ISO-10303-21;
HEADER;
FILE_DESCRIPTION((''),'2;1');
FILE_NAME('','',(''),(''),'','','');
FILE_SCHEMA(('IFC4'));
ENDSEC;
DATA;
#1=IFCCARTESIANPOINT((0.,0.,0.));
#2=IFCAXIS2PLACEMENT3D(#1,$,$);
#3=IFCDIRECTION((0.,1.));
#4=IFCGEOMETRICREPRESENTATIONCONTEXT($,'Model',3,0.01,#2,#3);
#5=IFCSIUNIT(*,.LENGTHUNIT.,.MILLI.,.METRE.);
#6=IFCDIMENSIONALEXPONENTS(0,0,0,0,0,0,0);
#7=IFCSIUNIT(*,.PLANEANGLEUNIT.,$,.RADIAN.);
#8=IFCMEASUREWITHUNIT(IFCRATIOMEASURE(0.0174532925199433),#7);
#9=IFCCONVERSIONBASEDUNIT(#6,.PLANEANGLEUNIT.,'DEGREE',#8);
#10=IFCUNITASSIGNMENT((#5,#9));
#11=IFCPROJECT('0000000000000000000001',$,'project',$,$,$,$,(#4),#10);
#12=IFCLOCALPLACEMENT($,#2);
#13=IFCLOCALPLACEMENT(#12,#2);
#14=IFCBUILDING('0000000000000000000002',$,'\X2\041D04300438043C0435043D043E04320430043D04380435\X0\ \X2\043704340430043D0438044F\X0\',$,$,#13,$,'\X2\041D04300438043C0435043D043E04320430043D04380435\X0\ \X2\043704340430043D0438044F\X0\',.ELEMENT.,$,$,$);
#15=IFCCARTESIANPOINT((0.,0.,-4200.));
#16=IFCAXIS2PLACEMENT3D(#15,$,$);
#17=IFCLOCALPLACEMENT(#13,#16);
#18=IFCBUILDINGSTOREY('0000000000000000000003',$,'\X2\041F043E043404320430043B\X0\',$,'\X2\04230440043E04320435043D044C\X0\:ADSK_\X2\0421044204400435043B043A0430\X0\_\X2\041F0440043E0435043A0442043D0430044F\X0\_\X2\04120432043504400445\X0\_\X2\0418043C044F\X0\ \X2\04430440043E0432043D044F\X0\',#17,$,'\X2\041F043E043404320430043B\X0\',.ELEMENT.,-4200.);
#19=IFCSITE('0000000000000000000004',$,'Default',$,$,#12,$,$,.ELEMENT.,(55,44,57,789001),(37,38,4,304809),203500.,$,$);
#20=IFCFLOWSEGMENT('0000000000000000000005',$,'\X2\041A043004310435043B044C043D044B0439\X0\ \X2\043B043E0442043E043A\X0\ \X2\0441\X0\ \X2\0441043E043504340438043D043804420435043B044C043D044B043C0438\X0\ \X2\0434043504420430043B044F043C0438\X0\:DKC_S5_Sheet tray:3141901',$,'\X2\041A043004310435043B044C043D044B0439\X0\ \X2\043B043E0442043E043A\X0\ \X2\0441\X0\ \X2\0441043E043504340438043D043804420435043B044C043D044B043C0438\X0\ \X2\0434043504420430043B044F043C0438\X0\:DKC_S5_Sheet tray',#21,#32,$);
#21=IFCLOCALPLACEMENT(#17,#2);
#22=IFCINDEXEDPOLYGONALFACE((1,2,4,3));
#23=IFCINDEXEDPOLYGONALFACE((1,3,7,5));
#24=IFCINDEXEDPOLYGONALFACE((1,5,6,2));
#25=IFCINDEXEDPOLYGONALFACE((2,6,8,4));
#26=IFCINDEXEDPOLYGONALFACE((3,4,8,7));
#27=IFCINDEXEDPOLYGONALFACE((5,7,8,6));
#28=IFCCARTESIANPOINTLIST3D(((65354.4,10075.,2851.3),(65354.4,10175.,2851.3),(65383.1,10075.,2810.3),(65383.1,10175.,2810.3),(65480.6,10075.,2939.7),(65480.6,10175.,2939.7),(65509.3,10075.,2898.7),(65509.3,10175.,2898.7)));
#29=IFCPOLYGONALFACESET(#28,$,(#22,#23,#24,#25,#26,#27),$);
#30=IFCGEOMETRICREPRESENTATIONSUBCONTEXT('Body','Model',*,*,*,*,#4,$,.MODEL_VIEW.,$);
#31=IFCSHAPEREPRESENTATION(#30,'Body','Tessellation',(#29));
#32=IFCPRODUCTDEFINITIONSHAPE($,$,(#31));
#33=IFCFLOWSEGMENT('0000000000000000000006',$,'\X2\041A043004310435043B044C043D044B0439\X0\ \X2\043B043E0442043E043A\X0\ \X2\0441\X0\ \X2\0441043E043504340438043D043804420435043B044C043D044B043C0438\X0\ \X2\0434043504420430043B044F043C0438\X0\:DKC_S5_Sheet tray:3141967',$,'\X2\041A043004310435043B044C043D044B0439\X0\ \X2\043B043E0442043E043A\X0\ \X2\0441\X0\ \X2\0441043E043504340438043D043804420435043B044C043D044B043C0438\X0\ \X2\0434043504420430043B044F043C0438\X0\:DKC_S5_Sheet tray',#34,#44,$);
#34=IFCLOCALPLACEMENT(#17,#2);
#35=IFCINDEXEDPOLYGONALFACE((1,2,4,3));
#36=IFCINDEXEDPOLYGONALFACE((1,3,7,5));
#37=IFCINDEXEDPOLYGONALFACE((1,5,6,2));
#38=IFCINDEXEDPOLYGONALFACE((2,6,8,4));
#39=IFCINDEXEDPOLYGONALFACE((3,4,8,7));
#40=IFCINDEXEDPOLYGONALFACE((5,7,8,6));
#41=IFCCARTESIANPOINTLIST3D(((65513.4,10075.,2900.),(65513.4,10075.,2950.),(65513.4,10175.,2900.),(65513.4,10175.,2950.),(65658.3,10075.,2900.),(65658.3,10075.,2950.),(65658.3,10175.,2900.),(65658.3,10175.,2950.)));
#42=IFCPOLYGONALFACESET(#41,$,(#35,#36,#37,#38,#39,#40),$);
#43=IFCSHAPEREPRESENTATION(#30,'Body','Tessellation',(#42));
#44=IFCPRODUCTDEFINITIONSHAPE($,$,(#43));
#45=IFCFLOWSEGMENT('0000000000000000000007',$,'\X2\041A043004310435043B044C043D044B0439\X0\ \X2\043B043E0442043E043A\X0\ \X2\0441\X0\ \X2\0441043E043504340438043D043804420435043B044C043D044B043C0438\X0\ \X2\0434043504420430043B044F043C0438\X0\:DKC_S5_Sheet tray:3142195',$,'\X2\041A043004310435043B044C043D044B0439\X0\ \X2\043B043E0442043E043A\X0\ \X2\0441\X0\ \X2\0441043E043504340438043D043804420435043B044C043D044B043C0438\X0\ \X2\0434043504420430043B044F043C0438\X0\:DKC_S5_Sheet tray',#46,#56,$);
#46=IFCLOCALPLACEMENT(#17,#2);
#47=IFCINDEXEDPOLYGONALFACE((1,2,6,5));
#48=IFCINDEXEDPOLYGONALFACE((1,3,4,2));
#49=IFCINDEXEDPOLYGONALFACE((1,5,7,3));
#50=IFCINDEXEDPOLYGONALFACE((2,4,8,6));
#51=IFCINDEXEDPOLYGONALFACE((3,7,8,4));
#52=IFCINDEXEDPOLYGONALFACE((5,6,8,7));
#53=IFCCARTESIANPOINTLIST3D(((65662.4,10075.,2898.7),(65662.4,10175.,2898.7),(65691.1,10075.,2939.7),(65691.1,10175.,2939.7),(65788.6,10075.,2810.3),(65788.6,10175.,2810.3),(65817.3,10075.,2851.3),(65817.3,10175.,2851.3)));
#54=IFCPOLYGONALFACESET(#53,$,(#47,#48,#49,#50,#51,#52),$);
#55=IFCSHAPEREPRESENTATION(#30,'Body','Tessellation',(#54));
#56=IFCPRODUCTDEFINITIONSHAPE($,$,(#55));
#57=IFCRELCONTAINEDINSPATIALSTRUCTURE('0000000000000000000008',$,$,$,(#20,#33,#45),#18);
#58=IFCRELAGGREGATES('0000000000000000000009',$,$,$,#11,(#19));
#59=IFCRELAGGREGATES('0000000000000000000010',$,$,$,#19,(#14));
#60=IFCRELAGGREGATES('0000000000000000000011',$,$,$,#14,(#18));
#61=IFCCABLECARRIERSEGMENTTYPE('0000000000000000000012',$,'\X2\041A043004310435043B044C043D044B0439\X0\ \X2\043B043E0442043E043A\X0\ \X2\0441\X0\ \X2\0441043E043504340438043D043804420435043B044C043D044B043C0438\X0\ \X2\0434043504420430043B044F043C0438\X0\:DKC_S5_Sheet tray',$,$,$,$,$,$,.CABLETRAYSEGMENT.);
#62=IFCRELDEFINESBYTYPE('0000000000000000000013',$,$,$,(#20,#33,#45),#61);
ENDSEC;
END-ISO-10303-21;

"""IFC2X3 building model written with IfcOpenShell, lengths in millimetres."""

from ifc_helpers import new_model, entity, si_unit, converted_unit, direction, frame, frame_2d, origin, place, context, subcontext, project, spatial, rectangle, extrude, type_object, element, save


model = new_model("IFC2X3")

# Units and contexts
model_context = context("Model", 3, precision=0.01, world=origin(), true_north=direction((0.0, 1.0)))
body_context = subcontext(model_context, "Body", "Model", "MODEL_VIEW")
ifc_project = project(units=[si_unit("LENGTHUNIT", "METRE", prefix="MILLI"), converted_unit("PLANEANGLEUNIT", "DEGREE", entity("IfcRatioMeasure", 0.0174532925199433), si_unit("PLANEANGLEUNIT", "RADIAN"), dimensions=[0, 0, 0, 0, 0, 0, 0])], contexts=[model_context])

# Site, building, storey
site_placement = place(None, frame((0.0, 0.0, 0.0)))
site = spatial("IfcSite", under=ifc_project, at=site_placement, Name="Default", CompositionType="ELEMENT", RefLatitude=(55, 44, 57, 789001), RefLongitude=(37, 38, 4, 304809), RefElevation=203500.0)
building_placement = place(site_placement, origin())
building = spatial("IfcBuilding", under=site, at=building_placement, Name="Наименование здания", LongName="Наименование здания", CompositionType="ELEMENT")
storey_placement = place(building_placement, frame((0.0, 0.0, -4200.0)))
storey = spatial("IfcBuildingStorey", under=building, at=storey_placement, Name="Подвал", ObjectType="Уровень:ADSK_Стрелка_Проектная_Вверх_Имя уровня", LongName="Подвал", CompositionType="ELEMENT", Elevation=-4200.0)

# Flow segments
cable_carrier_segment_type = type_object("IfcCableCarrierSegmentType", Name="Кабельный лоток с соединительными деталями:DKC_S5_Sheet tray", PredefinedType="CABLETRAYSEGMENT")
flow_segment_1_placement = place(storey_placement, frame((65354.4, 10075.0, 2810.3)))
element("IfcFlowSegment", 1, at=flow_segment_1_placement, inside=storey, type_object=cable_carrier_segment_type, Name="Кабельный лоток с соединительными деталями:DKC_S5_Sheet tray:3141901", ObjectType="Кабельный лоток с соединительными деталями:DKC_S5_Sheet tray", context=body_context, shape_type="SweptSolid", body=[
    extrude(rectangle(XDim=50.0, YDim=100.0, at=frame_2d((0.0, 0.0), x_axis=(0.0, 1.0))), frame((14.3, 50.0, 20.5), z_axis=(0.819152, 0.0, 0.573576), x_axis=(0.0, 1.0, 0.0)), (0.0, 0.0, 1.0), 154.1),
])
flow_segment_2_placement = place(storey_placement, frame((65513.4, 10075.0, 2900.0)))
element("IfcFlowSegment", 2, at=flow_segment_2_placement, inside=storey, type_object=cable_carrier_segment_type, Name="Кабельный лоток с соединительными деталями:DKC_S5_Sheet tray:3141967", ObjectType="Кабельный лоток с соединительными деталями:DKC_S5_Sheet tray", context=body_context, shape_type="SweptSolid", body=[
    extrude(rectangle(XDim=144.9, YDim=100.0, at=frame_2d((0.0, 0.0), x_axis=(1.0, 0.0))), frame((72.4, 50.0, 0.0), z_axis=(0.0, 0.0, 1.0), x_axis=(-1.0, 0.0, 0.0)), (0.0, 0.0, 1.0), 50.0),
])
flow_segment_3_placement = place(storey_placement, frame((65662.4, 10075.0, 2810.3)))
element("IfcFlowSegment", 3, at=flow_segment_3_placement, inside=storey, type_object=cable_carrier_segment_type, Name="Кабельный лоток с соединительными деталями:DKC_S5_Sheet tray:3142195", ObjectType="Кабельный лоток с соединительными деталями:DKC_S5_Sheet tray", context=body_context, shape_type="SweptSolid", body=[
    extrude(rectangle(XDim=50.0, YDim=100.0, at=frame_2d((0.0, 0.0), x_axis=(1.0, 0.0))), frame((14.3, 50.0, 108.8), z_axis=(0.819152, 0.0, -0.573576), x_axis=(0.573576, 0.0, 0.819152)), (0.0, 0.0, 1.0), 154.1),
])

save(model, "model.ifc")
